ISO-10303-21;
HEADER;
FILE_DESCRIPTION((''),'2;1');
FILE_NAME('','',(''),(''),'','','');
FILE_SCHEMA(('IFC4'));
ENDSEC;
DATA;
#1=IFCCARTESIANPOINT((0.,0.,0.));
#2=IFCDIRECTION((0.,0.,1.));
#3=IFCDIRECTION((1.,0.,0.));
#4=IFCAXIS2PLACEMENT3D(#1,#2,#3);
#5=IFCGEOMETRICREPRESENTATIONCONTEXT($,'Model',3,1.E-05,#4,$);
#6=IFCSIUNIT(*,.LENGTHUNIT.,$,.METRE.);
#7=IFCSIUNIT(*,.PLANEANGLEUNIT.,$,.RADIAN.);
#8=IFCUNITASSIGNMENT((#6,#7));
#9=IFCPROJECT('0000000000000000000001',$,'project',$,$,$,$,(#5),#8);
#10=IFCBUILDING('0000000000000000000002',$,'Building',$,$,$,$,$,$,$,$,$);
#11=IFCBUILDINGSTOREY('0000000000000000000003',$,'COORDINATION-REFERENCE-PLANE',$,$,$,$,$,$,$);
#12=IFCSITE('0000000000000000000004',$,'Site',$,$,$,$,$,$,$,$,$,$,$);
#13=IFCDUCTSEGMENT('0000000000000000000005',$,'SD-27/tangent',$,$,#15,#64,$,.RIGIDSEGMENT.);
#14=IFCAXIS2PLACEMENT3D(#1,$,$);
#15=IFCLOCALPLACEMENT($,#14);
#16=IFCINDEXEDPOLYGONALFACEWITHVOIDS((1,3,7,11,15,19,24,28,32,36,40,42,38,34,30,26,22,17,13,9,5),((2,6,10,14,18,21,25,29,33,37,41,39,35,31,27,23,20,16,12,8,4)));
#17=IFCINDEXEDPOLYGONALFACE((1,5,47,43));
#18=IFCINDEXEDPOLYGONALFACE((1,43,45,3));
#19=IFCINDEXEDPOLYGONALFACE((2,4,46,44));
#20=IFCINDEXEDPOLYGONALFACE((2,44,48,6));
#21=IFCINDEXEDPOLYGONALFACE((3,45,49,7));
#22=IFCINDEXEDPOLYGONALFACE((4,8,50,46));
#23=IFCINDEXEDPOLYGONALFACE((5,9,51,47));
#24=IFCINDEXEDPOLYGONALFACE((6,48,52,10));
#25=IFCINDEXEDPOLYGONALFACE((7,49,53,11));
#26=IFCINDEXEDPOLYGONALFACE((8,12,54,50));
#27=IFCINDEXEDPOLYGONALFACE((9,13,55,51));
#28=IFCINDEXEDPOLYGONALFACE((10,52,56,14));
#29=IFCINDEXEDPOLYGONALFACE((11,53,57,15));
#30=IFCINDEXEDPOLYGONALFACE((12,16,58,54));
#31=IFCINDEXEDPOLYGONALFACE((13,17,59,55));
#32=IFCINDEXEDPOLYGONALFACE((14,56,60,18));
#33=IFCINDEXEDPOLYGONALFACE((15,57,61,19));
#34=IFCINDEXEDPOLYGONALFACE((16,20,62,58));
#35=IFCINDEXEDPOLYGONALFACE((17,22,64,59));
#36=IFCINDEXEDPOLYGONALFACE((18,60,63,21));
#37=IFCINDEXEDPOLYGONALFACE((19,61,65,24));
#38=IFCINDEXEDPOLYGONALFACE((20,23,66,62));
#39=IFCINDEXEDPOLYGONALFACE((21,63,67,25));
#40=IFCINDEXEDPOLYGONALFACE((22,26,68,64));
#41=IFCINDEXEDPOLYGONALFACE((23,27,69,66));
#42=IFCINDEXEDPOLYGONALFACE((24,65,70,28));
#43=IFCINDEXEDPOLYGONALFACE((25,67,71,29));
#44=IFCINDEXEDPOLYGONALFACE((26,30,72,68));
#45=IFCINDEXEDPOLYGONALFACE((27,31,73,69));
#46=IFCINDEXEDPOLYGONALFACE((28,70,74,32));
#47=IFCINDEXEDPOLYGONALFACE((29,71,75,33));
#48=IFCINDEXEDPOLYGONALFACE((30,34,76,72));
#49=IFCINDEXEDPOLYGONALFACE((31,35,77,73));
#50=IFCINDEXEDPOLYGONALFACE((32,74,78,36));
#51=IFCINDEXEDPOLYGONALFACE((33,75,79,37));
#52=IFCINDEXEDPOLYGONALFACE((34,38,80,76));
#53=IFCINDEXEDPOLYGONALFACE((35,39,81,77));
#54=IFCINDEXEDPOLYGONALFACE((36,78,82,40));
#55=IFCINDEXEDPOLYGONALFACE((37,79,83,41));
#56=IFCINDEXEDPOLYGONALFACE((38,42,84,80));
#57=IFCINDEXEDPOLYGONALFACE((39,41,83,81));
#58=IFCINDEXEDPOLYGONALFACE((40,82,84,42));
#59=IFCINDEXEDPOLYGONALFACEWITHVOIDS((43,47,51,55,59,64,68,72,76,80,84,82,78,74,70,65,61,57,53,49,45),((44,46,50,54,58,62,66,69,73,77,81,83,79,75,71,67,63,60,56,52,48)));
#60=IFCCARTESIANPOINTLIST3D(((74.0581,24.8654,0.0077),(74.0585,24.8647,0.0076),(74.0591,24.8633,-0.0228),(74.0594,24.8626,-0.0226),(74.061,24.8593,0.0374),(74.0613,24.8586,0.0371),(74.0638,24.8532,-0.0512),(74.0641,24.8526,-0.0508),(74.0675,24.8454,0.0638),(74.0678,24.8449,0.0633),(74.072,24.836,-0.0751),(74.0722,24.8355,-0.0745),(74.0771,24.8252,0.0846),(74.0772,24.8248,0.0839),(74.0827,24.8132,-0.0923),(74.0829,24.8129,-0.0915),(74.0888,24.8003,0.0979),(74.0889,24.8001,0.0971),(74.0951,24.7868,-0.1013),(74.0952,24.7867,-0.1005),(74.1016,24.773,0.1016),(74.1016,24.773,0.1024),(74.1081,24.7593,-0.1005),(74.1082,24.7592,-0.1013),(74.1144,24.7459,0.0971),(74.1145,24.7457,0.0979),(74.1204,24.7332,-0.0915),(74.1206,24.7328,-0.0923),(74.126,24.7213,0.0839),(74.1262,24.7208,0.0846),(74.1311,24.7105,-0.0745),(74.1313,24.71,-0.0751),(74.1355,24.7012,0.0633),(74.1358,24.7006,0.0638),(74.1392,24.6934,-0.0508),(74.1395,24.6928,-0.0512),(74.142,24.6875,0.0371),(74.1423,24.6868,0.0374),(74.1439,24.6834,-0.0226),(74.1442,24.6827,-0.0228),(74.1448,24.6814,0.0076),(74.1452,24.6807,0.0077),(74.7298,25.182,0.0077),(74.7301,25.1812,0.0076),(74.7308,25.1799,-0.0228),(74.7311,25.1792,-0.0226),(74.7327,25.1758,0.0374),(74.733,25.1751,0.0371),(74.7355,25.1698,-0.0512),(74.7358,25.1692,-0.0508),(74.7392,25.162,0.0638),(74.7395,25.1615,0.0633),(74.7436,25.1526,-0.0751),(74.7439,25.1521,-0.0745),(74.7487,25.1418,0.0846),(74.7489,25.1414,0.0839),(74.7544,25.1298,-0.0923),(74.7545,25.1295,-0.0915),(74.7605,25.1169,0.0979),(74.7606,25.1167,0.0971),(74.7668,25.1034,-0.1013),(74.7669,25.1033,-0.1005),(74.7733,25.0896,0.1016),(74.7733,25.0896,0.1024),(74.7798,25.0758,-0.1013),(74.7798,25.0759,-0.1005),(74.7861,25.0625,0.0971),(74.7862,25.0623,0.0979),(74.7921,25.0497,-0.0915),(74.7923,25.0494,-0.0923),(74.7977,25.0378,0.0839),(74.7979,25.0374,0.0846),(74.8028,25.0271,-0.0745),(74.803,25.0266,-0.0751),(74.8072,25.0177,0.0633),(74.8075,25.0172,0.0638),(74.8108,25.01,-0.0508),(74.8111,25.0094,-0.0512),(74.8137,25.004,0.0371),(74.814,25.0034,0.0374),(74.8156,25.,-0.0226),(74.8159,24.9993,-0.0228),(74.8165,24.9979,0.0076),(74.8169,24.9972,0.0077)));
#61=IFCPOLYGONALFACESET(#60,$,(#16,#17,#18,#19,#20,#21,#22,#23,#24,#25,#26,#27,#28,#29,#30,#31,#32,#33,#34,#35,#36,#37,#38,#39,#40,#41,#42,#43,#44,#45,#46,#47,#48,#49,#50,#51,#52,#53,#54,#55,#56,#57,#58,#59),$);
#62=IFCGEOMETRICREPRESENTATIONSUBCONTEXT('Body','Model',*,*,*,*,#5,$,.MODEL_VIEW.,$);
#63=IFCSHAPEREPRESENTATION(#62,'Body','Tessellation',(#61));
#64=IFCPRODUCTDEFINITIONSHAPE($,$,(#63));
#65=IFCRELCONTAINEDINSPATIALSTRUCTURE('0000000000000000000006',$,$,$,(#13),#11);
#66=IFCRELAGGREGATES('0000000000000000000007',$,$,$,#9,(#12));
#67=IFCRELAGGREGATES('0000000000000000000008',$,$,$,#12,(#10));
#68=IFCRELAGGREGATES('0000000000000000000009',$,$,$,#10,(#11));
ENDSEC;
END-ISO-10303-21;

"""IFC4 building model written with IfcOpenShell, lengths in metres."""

from ifc_helpers import new_model, si_unit, frame, origin_with_axes, place, context, subcontext, project, spatial, hollow_circle, extrude, element, save


model = new_model("IFC4")

# Units and contexts
model_context = context("Model", 3, precision=1e-05, world=origin_with_axes())
body_context_1 = subcontext(model_context, "Body", "Model", "MODEL_VIEW")
ifc_project = project(units=[si_unit("LENGTHUNIT", "METRE"), si_unit("PLANEANGLEUNIT", "RADIAN")], contexts=[model_context])

# Site, building, storey
site = spatial("IfcSite", under=ifc_project, Name="Site")
building = spatial("IfcBuilding", under=site, Name="Building")
storey = spatial("IfcBuildingStorey", under=building, Name="COORDINATION-REFERENCE-PLANE")

# Duct segment
duct_segment_1_placement = place(None, frame((74.7733, 25.0896, 0.0), z_axis=(-0.904569, -0.426327, 0.0), x_axis=(0.0, 0.0, 1.0)))
element("IfcDuctSegment", 1, at=duct_segment_1_placement, inside=storey, Name="SD-27/tangent", PredefinedType="RIGIDSEGMENT", context=body_context_1, shape_type="SweptSolid", body=[
    extrude(hollow_circle(Radius=0.1024, WallThickness=0.0008), origin_with_axes(), (0.0, 0.0, 1.0), 0.7425),
])

save(model, "model.ifc")
